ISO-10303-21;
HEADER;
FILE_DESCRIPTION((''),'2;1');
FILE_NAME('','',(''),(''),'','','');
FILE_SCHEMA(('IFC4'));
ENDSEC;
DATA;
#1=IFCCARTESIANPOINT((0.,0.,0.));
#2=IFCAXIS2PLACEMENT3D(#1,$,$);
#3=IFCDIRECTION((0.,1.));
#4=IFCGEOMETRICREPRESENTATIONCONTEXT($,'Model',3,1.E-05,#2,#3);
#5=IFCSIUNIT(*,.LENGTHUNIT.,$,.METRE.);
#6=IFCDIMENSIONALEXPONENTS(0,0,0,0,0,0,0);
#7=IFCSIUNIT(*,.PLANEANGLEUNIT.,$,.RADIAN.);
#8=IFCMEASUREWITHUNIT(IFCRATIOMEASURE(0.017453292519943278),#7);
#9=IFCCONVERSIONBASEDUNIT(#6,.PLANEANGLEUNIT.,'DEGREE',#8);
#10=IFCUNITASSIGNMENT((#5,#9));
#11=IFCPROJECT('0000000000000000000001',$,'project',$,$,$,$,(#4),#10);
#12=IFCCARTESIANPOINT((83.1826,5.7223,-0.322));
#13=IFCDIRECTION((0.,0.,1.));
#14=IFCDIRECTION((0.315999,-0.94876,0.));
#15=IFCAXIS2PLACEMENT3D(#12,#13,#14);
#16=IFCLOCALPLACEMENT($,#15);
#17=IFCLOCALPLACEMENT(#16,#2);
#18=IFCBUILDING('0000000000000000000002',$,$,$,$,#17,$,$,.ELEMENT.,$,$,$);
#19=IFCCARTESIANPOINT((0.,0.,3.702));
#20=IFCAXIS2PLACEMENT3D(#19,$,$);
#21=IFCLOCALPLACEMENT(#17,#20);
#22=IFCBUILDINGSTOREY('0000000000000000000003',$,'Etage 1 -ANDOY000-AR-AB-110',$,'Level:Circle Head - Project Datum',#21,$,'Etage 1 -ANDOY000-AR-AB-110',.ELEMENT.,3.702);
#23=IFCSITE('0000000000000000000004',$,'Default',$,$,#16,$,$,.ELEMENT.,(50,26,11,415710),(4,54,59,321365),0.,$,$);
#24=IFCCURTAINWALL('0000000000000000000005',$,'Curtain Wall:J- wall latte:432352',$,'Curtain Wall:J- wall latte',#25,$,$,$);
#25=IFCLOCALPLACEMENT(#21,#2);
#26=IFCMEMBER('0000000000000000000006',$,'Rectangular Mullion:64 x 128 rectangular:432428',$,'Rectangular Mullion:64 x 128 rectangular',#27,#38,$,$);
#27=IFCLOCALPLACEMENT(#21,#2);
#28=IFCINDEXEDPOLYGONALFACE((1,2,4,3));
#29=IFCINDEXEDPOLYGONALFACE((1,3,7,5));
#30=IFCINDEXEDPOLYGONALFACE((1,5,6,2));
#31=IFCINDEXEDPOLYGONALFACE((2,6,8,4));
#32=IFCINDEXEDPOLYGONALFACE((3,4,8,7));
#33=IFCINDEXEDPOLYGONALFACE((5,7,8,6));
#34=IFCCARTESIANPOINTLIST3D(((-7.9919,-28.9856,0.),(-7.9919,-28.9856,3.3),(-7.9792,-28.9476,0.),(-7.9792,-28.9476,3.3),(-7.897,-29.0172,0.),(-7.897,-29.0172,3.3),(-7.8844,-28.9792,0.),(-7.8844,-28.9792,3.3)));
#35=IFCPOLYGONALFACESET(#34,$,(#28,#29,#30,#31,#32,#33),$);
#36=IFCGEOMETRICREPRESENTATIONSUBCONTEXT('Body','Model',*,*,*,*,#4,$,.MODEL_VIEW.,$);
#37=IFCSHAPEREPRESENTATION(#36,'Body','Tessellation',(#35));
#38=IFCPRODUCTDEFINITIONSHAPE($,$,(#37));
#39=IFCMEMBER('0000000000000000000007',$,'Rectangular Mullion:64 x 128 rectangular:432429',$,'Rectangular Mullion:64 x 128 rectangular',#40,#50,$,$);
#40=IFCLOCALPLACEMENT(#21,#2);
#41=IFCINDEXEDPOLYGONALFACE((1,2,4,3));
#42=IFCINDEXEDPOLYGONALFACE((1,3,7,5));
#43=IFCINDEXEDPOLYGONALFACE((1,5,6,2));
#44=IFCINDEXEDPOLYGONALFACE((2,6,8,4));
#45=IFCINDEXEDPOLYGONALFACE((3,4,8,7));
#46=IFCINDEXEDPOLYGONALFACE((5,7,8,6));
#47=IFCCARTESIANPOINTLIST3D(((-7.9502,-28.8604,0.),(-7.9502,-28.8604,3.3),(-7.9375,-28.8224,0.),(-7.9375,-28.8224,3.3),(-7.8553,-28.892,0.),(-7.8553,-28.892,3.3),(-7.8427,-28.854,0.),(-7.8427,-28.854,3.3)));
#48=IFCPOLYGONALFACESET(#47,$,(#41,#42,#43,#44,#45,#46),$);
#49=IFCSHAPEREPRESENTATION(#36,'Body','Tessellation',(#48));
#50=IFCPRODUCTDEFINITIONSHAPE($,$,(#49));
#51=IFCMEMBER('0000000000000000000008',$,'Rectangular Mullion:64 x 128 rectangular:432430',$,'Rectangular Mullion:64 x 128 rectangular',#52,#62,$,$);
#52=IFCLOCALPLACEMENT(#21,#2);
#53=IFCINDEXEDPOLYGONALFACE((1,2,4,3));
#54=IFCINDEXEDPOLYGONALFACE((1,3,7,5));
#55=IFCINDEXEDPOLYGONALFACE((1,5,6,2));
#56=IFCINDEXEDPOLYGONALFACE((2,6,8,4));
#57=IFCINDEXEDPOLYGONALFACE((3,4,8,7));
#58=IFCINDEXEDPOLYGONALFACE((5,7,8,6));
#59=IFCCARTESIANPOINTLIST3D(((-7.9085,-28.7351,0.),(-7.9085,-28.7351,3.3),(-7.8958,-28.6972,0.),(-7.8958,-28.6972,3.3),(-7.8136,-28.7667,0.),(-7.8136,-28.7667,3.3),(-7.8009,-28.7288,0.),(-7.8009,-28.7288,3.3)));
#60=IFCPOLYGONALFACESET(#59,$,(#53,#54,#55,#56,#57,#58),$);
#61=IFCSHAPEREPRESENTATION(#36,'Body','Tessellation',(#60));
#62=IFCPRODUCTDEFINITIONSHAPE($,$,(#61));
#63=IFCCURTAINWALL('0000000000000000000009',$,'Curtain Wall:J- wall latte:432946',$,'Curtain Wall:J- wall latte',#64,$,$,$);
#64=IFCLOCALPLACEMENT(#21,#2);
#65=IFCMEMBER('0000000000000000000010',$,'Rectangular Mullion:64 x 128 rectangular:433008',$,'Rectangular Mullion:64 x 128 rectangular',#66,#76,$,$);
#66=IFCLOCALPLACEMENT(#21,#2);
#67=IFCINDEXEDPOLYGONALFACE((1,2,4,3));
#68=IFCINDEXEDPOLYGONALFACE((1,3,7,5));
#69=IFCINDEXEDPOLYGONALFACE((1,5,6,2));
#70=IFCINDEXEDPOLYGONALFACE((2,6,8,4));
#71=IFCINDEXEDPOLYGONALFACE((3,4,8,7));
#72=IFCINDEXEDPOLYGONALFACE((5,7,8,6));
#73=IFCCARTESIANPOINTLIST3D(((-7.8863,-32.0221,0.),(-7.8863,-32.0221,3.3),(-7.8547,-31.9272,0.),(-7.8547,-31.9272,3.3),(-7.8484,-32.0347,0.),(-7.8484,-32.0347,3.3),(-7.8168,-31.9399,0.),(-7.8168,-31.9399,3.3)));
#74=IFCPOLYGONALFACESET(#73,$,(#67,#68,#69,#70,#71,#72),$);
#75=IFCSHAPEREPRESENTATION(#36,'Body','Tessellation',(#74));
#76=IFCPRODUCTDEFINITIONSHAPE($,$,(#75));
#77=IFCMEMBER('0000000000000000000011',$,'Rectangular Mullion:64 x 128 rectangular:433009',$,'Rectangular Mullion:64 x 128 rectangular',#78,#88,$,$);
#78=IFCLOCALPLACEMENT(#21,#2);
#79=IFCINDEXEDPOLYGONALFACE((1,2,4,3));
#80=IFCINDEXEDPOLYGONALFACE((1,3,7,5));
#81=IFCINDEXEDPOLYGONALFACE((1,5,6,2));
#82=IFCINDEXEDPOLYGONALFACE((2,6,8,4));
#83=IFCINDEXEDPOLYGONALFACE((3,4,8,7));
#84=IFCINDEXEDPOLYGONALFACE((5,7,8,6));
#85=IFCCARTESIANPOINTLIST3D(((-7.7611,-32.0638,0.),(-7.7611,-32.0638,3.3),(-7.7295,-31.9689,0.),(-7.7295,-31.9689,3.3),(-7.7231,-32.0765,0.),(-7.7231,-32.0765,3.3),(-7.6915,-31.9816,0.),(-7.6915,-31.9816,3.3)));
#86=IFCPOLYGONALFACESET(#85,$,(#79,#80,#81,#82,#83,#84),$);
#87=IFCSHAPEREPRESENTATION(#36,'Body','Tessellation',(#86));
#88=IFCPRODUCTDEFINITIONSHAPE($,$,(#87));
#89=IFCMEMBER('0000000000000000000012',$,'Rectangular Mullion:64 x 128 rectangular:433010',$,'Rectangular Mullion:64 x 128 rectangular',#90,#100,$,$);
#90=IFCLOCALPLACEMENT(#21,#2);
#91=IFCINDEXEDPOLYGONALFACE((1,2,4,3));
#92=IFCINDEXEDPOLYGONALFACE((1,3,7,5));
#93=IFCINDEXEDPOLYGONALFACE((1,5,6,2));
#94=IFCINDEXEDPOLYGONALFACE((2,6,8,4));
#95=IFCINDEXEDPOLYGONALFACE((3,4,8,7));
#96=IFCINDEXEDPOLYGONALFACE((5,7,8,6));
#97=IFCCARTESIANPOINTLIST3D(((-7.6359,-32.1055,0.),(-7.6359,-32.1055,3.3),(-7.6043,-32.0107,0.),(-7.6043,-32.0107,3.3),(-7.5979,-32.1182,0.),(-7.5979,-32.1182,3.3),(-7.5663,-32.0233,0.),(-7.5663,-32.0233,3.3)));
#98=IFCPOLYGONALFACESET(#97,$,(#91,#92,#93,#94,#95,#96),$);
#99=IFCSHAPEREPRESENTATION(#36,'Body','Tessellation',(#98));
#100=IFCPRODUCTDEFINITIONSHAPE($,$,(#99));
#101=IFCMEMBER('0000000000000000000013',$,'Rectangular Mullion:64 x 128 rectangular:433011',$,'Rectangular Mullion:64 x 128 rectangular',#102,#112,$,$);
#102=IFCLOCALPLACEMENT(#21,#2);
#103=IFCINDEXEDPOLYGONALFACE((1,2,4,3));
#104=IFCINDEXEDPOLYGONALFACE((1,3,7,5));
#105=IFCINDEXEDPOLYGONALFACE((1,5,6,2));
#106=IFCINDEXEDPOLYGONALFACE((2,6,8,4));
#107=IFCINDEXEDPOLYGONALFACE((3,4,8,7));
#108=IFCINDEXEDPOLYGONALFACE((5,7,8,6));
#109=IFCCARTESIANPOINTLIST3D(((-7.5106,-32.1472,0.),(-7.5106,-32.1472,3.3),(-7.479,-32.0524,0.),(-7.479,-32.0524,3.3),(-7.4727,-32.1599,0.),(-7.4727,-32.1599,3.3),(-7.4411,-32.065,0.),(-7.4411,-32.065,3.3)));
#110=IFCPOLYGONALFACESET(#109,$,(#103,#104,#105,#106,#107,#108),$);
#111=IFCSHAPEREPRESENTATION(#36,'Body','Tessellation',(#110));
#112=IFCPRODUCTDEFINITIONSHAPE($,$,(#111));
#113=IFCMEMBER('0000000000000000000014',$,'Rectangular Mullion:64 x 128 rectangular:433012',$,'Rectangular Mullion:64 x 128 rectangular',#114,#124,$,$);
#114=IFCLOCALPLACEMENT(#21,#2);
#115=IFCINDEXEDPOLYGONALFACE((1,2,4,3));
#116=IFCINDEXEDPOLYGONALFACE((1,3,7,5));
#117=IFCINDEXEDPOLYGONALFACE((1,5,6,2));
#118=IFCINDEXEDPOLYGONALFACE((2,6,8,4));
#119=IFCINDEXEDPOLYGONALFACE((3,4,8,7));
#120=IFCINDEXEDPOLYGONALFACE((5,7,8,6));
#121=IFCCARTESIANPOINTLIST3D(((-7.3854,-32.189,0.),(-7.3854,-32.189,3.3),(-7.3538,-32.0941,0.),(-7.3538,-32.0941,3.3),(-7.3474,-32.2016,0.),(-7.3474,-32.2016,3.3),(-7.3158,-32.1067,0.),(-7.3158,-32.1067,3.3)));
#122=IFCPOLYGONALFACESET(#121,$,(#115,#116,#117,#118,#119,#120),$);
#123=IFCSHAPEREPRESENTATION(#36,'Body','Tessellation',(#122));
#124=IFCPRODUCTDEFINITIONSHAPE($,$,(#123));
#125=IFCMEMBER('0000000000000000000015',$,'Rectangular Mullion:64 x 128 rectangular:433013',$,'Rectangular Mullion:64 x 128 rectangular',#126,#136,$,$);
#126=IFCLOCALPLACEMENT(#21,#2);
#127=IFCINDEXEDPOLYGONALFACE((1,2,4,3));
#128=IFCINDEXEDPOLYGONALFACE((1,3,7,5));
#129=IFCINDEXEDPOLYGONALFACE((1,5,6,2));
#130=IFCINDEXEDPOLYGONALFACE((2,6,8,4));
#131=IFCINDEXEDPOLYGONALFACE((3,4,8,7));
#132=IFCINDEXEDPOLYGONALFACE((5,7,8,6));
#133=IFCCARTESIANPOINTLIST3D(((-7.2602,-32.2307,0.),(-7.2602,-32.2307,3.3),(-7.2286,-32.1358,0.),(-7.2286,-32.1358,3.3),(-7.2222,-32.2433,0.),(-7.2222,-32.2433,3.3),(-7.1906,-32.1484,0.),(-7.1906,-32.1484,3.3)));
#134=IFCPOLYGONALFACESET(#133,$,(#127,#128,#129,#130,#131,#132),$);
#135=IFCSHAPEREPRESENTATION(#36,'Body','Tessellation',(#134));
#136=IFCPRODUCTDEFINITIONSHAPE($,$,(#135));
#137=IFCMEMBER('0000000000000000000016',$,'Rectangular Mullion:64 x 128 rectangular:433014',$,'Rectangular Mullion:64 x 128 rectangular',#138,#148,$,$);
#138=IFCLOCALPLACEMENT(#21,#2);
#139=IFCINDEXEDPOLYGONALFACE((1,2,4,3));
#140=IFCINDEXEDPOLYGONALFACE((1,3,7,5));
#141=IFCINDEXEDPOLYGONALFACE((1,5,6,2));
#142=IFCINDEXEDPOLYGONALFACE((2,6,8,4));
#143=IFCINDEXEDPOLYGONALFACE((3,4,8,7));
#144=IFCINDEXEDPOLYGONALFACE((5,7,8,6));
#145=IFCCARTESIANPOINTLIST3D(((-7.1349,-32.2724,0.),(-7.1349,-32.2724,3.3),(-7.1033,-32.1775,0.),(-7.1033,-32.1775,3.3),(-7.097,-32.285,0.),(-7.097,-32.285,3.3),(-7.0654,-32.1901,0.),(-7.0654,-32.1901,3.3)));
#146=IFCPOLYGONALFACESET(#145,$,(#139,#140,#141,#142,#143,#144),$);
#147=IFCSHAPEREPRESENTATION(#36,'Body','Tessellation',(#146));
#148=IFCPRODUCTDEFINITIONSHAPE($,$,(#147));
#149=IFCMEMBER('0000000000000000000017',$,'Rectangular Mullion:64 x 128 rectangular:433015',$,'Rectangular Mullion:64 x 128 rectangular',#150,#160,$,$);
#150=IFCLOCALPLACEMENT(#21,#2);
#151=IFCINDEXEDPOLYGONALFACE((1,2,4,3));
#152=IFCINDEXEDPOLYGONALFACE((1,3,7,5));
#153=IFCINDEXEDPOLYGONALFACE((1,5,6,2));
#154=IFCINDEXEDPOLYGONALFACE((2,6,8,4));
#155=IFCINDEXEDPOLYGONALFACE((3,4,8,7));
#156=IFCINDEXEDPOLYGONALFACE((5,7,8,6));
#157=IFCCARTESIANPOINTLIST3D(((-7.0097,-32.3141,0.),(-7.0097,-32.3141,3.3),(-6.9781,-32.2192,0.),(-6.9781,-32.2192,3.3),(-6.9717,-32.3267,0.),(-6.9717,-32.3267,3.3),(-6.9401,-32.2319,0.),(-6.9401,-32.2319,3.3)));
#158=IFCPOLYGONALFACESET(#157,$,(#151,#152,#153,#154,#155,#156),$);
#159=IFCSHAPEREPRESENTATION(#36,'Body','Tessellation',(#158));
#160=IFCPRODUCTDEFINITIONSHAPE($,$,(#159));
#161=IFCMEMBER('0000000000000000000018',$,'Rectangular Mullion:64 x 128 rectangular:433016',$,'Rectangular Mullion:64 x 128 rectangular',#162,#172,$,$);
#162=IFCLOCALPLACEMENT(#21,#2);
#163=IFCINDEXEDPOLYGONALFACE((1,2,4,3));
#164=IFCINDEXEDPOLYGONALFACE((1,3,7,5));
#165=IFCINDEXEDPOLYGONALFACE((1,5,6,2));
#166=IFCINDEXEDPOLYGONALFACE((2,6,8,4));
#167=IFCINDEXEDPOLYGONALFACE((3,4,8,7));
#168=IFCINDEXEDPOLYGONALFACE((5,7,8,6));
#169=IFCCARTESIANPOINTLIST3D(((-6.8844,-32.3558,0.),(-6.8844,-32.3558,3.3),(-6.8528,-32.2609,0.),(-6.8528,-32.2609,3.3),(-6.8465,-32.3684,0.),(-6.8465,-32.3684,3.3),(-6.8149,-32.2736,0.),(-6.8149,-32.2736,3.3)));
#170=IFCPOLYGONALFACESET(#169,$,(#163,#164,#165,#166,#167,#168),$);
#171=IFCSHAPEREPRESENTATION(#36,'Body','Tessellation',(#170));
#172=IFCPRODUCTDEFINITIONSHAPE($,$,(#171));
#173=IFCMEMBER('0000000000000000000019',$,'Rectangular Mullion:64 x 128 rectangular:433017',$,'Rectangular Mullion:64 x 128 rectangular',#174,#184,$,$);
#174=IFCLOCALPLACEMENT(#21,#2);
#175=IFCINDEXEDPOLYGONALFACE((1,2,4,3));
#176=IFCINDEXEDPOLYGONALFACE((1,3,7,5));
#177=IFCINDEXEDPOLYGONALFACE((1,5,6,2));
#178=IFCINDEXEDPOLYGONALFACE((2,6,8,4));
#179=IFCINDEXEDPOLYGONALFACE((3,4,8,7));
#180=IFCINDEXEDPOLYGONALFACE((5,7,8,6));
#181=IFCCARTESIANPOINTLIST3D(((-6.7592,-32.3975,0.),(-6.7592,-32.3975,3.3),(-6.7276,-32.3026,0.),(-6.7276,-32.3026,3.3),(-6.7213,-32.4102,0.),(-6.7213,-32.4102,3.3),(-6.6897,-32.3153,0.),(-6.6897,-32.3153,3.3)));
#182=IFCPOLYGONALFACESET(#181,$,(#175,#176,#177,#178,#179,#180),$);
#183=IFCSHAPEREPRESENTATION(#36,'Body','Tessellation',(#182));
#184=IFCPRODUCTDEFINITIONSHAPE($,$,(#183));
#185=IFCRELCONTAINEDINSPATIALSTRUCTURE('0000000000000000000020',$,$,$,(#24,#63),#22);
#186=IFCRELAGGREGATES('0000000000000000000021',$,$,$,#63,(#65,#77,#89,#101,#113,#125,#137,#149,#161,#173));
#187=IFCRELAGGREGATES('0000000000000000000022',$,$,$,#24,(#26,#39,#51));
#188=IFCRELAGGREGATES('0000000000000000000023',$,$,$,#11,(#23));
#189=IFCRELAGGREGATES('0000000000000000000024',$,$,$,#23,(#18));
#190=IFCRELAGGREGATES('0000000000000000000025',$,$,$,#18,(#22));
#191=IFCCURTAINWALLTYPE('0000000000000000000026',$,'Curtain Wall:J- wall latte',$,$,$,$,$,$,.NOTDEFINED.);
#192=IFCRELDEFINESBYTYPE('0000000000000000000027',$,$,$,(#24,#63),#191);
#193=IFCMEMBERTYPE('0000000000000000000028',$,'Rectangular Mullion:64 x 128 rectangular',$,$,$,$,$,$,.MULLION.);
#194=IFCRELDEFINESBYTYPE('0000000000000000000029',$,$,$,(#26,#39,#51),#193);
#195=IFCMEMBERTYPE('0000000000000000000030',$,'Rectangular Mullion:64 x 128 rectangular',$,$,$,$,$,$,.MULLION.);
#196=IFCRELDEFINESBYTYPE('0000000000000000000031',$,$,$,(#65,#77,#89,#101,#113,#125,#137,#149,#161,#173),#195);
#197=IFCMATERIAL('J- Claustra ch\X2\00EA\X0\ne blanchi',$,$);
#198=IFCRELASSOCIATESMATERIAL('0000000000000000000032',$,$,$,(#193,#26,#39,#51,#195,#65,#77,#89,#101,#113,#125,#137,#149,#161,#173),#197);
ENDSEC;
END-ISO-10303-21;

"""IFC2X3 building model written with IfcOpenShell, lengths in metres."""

from ifc_helpers import new_model, entity, si_unit, converted_unit, direction, frame, origin, origin_2d_with_axis, place, context, subcontext, project, spatial, rectangle, extrude, source, transform, mapped, material, type_object, type_shapes, element, aggregate, save


model = new_model("IFC2X3")

# Units and contexts
model_context = context("Model", 3, precision=1e-05, world=origin(), true_north=direction((0.0, 1.0)))
body_context = subcontext(model_context, "Body", "Model", "MODEL_VIEW")
ifc_project = project(units=[si_unit("LENGTHUNIT", "METRE"), converted_unit("PLANEANGLEUNIT", "DEGREE", entity("IfcRatioMeasure", 0.017453292519943278), si_unit("PLANEANGLEUNIT", "RADIAN"), dimensions=[0, 0, 0, 0, 0, 0, 0])], contexts=[model_context])

# Site, building, storey
site_placement = place(None, frame((83.1826, 5.7223, -0.322), z_axis=(0.0, 0.0, 1.0), x_axis=(0.315999, -0.94876, 0.0)))
site = spatial("IfcSite", under=ifc_project, at=site_placement, Name="Default", CompositionType="ELEMENT", RefLatitude=(50, 26, 11, 415710), RefLongitude=(4, 54, 59, 321365), RefElevation=0.0)
building_placement = place(site_placement, origin())
building = spatial("IfcBuilding", under=site, at=building_placement, CompositionType="ELEMENT")
storey_placement = place(building_placement, frame((0.0, 0.0, 3.702)))
storey = spatial("IfcBuildingStorey", under=building, at=storey_placement, Name="Etage 1 -ANDOY000-AR-AB-110", ObjectType="Level:Circle Head - Project Datum", LongName="Etage 1 -ANDOY000-AR-AB-110", CompositionType="ELEMENT", Elevation=3.702)

# Curtain walls, members
curtain_wall_type = type_object("IfcCurtainWallType", Name="Curtain Wall:J- wall latte", PredefinedType="NOTDEFINED")
curtain_wall_1_placement = place(storey_placement, frame((0.0, 0.0, -3.702)))
curtain_wall_1 = element("IfcCurtainWall", 1, at=curtain_wall_1_placement, inside=storey, type_object=curtain_wall_type, Name="Curtain Wall:J- wall latte:432352", ObjectType="Curtain Wall:J- wall latte")
ifc_material_1 = material(Name="J- Claustra chêne blanchi")
member_type_1 = type_object("IfcMemberType", Name="Rectangular Mullion:64 x 128 rectangular", PredefinedType="MULLION", material=ifc_material_1)
shared_shape_1 = source(origin(), body_context, "Body", "SweptSolid", [
    extrude(rectangle(XDim=0.1, YDim=0.04, at=origin_2d_with_axis()), frame((0.0, 0.0, -3.3), z_axis=(0.0, 0.0, 1.0), x_axis=(0.0, -1.0, 0.0)), (0.0, 0.0, 1.0), 3.3),
])
type_shapes(member_type_1, [shared_shape_1])
member_1_placement = place(curtain_wall_1_placement, frame((-7.9381, -28.9824, 3.702), z_axis=(0.0, 0.0, -1.0), x_axis=(0.316, 0.948759, 0.0)))
member_1 = element("IfcMember", 2, at=member_1_placement, type_object=member_type_1, material=ifc_material_1, Name="Rectangular Mullion:64 x 128 rectangular:432428", ObjectType="Rectangular Mullion:64 x 128 rectangular", context=body_context, shape_type="MappedRepresentation", body=[
    mapped(shared_shape_1, transform((0.0, 0.0, 0.0), scale=1.0)),
])
member_2_placement = place(curtain_wall_1_placement, frame((-7.8964, -28.8572, 3.702), z_axis=(0.0, 0.0, -1.0), x_axis=(0.316, 0.948759, 0.0)))
member_2 = element("IfcMember", 3, at=member_2_placement, type_object=member_type_1, material=ifc_material_1, Name="Rectangular Mullion:64 x 128 rectangular:432429", ObjectType="Rectangular Mullion:64 x 128 rectangular", context=body_context, shape_type="MappedRepresentation", body=[
    mapped(shared_shape_1, transform((0.0, 0.0, 0.0), scale=1.0)),
])
member_3_placement = place(curtain_wall_1_placement, frame((-7.8547, -28.7319, 3.702), z_axis=(0.0, 0.0, -1.0), x_axis=(0.316, 0.948759, 0.0)))
member_3 = element("IfcMember", 4, at=member_3_placement, type_object=member_type_1, material=ifc_material_1, Name="Rectangular Mullion:64 x 128 rectangular:432430", ObjectType="Rectangular Mullion:64 x 128 rectangular", context=body_context, shape_type="MappedRepresentation", body=[
    mapped(shared_shape_1, transform((0.0, 0.0, 0.0), scale=1.0)),
])
curtain_wall_2_placement = place(storey_placement, frame((0.0, 0.0, -3.702)))
curtain_wall_2 = element("IfcCurtainWall", 5, at=curtain_wall_2_placement, inside=storey, type_object=curtain_wall_type, Name="Curtain Wall:J- wall latte:432946", ObjectType="Curtain Wall:J- wall latte")
member_type_2 = type_object("IfcMemberType", Name="Rectangular Mullion:64 x 128 rectangular", PredefinedType="MULLION", material=ifc_material_1)
shared_shape_2 = source(origin(), body_context, "Body", "SweptSolid", [
    extrude(rectangle(XDim=0.1, YDim=0.04, at=origin_2d_with_axis()), frame((0.0, 0.0, -3.3), z_axis=(0.0, 0.0, 1.0), x_axis=(0.0, -1.0, 0.0)), (0.0, 0.0, 1.0), 3.3),
])
type_shapes(member_type_2, [shared_shape_2])
member_4_placement = place(curtain_wall_2_placement, frame((-7.8516, -31.981, 3.702), z_axis=(0.0, 0.0, -1.0), x_axis=(0.948759, -0.316, 0.0)))
member_4 = element("IfcMember", 6, at=member_4_placement, type_object=member_type_2, material=ifc_material_1, Name="Rectangular Mullion:64 x 128 rectangular:433008", ObjectType="Rectangular Mullion:64 x 128 rectangular", context=body_context, shape_type="MappedRepresentation", body=[
    mapped(shared_shape_2, transform((0.0, 0.0, 0.0), scale=1.0)),
])
member_5_placement = place(curtain_wall_2_placement, frame((-7.7263, -32.0227, 3.702), z_axis=(0.0, 0.0, -1.0), x_axis=(0.948759, -0.316, 0.0)))
member_5 = element("IfcMember", 7, at=member_5_placement, type_object=member_type_2, material=ifc_material_1, Name="Rectangular Mullion:64 x 128 rectangular:433009", ObjectType="Rectangular Mullion:64 x 128 rectangular", context=body_context, shape_type="MappedRepresentation", body=[
    mapped(shared_shape_2, transform((0.0, 0.0, 0.0), scale=1.0)),
])
member_6_placement = place(curtain_wall_2_placement, frame((-7.6011, -32.0644, 3.702), z_axis=(0.0, 0.0, -1.0), x_axis=(0.948759, -0.316, 0.0)))
member_6 = element("IfcMember", 8, at=member_6_placement, type_object=member_type_2, material=ifc_material_1, Name="Rectangular Mullion:64 x 128 rectangular:433010", ObjectType="Rectangular Mullion:64 x 128 rectangular", context=body_context, shape_type="MappedRepresentation", body=[
    mapped(shared_shape_2, transform((0.0, 0.0, 0.0), scale=1.0)),
])
member_7_placement = place(curtain_wall_2_placement, frame((-7.4759, -32.1061, 3.702), z_axis=(0.0, 0.0, -1.0), x_axis=(0.948759, -0.316, 0.0)))
member_7 = element("IfcMember", 9, at=member_7_placement, type_object=member_type_2, material=ifc_material_1, Name="Rectangular Mullion:64 x 128 rectangular:433011", ObjectType="Rectangular Mullion:64 x 128 rectangular", context=body_context, shape_type="MappedRepresentation", body=[
    mapped(shared_shape_2, transform((0.0, 0.0, 0.0), scale=1.0)),
])
member_8_placement = place(curtain_wall_2_placement, frame((-7.3506, -32.1478, 3.702), z_axis=(0.0, 0.0, -1.0), x_axis=(0.948759, -0.316, 0.0)))
member_8 = element("IfcMember", 10, at=member_8_placement, type_object=member_type_2, material=ifc_material_1, Name="Rectangular Mullion:64 x 128 rectangular:433012", ObjectType="Rectangular Mullion:64 x 128 rectangular", context=body_context, shape_type="MappedRepresentation", body=[
    mapped(shared_shape_2, transform((0.0, 0.0, 0.0), scale=1.0)),
])
member_9_placement = place(curtain_wall_2_placement, frame((-7.2254, -32.1895, 3.702), z_axis=(0.0, 0.0, -1.0), x_axis=(0.948759, -0.316, 0.0)))
member_9 = element("IfcMember", 11, at=member_9_placement, type_object=member_type_2, material=ifc_material_1, Name="Rectangular Mullion:64 x 128 rectangular:433013", ObjectType="Rectangular Mullion:64 x 128 rectangular", context=body_context, shape_type="MappedRepresentation", body=[
    mapped(shared_shape_2, transform((0.0, 0.0, 0.0), scale=1.0)),
])
member_10_placement = place(curtain_wall_2_placement, frame((-7.1001, -32.2313, 3.702), z_axis=(0.0, 0.0, -1.0), x_axis=(0.948759, -0.316, 0.0)))
member_10 = element("IfcMember", 12, at=member_10_placement, type_object=member_type_2, material=ifc_material_1, Name="Rectangular Mullion:64 x 128 rectangular:433014", ObjectType="Rectangular Mullion:64 x 128 rectangular", context=body_context, shape_type="MappedRepresentation", body=[
    mapped(shared_shape_2, transform((0.0, 0.0, 0.0), scale=1.0)),
])
member_11_placement = place(curtain_wall_2_placement, frame((-6.9749, -32.273, 3.702), z_axis=(0.0, 0.0, -1.0), x_axis=(0.948759, -0.316, 0.0)))
member_11 = element("IfcMember", 13, at=member_11_placement, type_object=member_type_2, material=ifc_material_1, Name="Rectangular Mullion:64 x 128 rectangular:433015", ObjectType="Rectangular Mullion:64 x 128 rectangular", context=body_context, shape_type="MappedRepresentation", body=[
    mapped(shared_shape_2, transform((0.0, 0.0, 0.0), scale=1.0)),
])
member_12_placement = place(curtain_wall_2_placement, frame((-6.8497, -32.3147, 3.702), z_axis=(0.0, 0.0, -1.0), x_axis=(0.948759, -0.316, 0.0)))
member_12 = element("IfcMember", 14, at=member_12_placement, type_object=member_type_2, material=ifc_material_1, Name="Rectangular Mullion:64 x 128 rectangular:433016", ObjectType="Rectangular Mullion:64 x 128 rectangular", context=body_context, shape_type="MappedRepresentation", body=[
    mapped(shared_shape_2, transform((0.0, 0.0, 0.0), scale=1.0)),
])
member_13_placement = place(curtain_wall_2_placement, frame((-6.7244, -32.3564, 3.702), z_axis=(0.0, 0.0, -1.0), x_axis=(0.948759, -0.316, 0.0)))
member_13 = element("IfcMember", 15, at=member_13_placement, type_object=member_type_2, material=ifc_material_1, Name="Rectangular Mullion:64 x 128 rectangular:433017", ObjectType="Rectangular Mullion:64 x 128 rectangular", context=body_context, shape_type="MappedRepresentation", body=[
    mapped(shared_shape_2, transform((0.0, 0.0, 0.0), scale=1.0)),
])

aggregate(curtain_wall_2, [member_4, member_5, member_6, member_7, member_8, member_9, member_10, member_11, member_12, member_13])
aggregate(curtain_wall_1, [member_1, member_2, member_3])

save(model, "model.ifc")
